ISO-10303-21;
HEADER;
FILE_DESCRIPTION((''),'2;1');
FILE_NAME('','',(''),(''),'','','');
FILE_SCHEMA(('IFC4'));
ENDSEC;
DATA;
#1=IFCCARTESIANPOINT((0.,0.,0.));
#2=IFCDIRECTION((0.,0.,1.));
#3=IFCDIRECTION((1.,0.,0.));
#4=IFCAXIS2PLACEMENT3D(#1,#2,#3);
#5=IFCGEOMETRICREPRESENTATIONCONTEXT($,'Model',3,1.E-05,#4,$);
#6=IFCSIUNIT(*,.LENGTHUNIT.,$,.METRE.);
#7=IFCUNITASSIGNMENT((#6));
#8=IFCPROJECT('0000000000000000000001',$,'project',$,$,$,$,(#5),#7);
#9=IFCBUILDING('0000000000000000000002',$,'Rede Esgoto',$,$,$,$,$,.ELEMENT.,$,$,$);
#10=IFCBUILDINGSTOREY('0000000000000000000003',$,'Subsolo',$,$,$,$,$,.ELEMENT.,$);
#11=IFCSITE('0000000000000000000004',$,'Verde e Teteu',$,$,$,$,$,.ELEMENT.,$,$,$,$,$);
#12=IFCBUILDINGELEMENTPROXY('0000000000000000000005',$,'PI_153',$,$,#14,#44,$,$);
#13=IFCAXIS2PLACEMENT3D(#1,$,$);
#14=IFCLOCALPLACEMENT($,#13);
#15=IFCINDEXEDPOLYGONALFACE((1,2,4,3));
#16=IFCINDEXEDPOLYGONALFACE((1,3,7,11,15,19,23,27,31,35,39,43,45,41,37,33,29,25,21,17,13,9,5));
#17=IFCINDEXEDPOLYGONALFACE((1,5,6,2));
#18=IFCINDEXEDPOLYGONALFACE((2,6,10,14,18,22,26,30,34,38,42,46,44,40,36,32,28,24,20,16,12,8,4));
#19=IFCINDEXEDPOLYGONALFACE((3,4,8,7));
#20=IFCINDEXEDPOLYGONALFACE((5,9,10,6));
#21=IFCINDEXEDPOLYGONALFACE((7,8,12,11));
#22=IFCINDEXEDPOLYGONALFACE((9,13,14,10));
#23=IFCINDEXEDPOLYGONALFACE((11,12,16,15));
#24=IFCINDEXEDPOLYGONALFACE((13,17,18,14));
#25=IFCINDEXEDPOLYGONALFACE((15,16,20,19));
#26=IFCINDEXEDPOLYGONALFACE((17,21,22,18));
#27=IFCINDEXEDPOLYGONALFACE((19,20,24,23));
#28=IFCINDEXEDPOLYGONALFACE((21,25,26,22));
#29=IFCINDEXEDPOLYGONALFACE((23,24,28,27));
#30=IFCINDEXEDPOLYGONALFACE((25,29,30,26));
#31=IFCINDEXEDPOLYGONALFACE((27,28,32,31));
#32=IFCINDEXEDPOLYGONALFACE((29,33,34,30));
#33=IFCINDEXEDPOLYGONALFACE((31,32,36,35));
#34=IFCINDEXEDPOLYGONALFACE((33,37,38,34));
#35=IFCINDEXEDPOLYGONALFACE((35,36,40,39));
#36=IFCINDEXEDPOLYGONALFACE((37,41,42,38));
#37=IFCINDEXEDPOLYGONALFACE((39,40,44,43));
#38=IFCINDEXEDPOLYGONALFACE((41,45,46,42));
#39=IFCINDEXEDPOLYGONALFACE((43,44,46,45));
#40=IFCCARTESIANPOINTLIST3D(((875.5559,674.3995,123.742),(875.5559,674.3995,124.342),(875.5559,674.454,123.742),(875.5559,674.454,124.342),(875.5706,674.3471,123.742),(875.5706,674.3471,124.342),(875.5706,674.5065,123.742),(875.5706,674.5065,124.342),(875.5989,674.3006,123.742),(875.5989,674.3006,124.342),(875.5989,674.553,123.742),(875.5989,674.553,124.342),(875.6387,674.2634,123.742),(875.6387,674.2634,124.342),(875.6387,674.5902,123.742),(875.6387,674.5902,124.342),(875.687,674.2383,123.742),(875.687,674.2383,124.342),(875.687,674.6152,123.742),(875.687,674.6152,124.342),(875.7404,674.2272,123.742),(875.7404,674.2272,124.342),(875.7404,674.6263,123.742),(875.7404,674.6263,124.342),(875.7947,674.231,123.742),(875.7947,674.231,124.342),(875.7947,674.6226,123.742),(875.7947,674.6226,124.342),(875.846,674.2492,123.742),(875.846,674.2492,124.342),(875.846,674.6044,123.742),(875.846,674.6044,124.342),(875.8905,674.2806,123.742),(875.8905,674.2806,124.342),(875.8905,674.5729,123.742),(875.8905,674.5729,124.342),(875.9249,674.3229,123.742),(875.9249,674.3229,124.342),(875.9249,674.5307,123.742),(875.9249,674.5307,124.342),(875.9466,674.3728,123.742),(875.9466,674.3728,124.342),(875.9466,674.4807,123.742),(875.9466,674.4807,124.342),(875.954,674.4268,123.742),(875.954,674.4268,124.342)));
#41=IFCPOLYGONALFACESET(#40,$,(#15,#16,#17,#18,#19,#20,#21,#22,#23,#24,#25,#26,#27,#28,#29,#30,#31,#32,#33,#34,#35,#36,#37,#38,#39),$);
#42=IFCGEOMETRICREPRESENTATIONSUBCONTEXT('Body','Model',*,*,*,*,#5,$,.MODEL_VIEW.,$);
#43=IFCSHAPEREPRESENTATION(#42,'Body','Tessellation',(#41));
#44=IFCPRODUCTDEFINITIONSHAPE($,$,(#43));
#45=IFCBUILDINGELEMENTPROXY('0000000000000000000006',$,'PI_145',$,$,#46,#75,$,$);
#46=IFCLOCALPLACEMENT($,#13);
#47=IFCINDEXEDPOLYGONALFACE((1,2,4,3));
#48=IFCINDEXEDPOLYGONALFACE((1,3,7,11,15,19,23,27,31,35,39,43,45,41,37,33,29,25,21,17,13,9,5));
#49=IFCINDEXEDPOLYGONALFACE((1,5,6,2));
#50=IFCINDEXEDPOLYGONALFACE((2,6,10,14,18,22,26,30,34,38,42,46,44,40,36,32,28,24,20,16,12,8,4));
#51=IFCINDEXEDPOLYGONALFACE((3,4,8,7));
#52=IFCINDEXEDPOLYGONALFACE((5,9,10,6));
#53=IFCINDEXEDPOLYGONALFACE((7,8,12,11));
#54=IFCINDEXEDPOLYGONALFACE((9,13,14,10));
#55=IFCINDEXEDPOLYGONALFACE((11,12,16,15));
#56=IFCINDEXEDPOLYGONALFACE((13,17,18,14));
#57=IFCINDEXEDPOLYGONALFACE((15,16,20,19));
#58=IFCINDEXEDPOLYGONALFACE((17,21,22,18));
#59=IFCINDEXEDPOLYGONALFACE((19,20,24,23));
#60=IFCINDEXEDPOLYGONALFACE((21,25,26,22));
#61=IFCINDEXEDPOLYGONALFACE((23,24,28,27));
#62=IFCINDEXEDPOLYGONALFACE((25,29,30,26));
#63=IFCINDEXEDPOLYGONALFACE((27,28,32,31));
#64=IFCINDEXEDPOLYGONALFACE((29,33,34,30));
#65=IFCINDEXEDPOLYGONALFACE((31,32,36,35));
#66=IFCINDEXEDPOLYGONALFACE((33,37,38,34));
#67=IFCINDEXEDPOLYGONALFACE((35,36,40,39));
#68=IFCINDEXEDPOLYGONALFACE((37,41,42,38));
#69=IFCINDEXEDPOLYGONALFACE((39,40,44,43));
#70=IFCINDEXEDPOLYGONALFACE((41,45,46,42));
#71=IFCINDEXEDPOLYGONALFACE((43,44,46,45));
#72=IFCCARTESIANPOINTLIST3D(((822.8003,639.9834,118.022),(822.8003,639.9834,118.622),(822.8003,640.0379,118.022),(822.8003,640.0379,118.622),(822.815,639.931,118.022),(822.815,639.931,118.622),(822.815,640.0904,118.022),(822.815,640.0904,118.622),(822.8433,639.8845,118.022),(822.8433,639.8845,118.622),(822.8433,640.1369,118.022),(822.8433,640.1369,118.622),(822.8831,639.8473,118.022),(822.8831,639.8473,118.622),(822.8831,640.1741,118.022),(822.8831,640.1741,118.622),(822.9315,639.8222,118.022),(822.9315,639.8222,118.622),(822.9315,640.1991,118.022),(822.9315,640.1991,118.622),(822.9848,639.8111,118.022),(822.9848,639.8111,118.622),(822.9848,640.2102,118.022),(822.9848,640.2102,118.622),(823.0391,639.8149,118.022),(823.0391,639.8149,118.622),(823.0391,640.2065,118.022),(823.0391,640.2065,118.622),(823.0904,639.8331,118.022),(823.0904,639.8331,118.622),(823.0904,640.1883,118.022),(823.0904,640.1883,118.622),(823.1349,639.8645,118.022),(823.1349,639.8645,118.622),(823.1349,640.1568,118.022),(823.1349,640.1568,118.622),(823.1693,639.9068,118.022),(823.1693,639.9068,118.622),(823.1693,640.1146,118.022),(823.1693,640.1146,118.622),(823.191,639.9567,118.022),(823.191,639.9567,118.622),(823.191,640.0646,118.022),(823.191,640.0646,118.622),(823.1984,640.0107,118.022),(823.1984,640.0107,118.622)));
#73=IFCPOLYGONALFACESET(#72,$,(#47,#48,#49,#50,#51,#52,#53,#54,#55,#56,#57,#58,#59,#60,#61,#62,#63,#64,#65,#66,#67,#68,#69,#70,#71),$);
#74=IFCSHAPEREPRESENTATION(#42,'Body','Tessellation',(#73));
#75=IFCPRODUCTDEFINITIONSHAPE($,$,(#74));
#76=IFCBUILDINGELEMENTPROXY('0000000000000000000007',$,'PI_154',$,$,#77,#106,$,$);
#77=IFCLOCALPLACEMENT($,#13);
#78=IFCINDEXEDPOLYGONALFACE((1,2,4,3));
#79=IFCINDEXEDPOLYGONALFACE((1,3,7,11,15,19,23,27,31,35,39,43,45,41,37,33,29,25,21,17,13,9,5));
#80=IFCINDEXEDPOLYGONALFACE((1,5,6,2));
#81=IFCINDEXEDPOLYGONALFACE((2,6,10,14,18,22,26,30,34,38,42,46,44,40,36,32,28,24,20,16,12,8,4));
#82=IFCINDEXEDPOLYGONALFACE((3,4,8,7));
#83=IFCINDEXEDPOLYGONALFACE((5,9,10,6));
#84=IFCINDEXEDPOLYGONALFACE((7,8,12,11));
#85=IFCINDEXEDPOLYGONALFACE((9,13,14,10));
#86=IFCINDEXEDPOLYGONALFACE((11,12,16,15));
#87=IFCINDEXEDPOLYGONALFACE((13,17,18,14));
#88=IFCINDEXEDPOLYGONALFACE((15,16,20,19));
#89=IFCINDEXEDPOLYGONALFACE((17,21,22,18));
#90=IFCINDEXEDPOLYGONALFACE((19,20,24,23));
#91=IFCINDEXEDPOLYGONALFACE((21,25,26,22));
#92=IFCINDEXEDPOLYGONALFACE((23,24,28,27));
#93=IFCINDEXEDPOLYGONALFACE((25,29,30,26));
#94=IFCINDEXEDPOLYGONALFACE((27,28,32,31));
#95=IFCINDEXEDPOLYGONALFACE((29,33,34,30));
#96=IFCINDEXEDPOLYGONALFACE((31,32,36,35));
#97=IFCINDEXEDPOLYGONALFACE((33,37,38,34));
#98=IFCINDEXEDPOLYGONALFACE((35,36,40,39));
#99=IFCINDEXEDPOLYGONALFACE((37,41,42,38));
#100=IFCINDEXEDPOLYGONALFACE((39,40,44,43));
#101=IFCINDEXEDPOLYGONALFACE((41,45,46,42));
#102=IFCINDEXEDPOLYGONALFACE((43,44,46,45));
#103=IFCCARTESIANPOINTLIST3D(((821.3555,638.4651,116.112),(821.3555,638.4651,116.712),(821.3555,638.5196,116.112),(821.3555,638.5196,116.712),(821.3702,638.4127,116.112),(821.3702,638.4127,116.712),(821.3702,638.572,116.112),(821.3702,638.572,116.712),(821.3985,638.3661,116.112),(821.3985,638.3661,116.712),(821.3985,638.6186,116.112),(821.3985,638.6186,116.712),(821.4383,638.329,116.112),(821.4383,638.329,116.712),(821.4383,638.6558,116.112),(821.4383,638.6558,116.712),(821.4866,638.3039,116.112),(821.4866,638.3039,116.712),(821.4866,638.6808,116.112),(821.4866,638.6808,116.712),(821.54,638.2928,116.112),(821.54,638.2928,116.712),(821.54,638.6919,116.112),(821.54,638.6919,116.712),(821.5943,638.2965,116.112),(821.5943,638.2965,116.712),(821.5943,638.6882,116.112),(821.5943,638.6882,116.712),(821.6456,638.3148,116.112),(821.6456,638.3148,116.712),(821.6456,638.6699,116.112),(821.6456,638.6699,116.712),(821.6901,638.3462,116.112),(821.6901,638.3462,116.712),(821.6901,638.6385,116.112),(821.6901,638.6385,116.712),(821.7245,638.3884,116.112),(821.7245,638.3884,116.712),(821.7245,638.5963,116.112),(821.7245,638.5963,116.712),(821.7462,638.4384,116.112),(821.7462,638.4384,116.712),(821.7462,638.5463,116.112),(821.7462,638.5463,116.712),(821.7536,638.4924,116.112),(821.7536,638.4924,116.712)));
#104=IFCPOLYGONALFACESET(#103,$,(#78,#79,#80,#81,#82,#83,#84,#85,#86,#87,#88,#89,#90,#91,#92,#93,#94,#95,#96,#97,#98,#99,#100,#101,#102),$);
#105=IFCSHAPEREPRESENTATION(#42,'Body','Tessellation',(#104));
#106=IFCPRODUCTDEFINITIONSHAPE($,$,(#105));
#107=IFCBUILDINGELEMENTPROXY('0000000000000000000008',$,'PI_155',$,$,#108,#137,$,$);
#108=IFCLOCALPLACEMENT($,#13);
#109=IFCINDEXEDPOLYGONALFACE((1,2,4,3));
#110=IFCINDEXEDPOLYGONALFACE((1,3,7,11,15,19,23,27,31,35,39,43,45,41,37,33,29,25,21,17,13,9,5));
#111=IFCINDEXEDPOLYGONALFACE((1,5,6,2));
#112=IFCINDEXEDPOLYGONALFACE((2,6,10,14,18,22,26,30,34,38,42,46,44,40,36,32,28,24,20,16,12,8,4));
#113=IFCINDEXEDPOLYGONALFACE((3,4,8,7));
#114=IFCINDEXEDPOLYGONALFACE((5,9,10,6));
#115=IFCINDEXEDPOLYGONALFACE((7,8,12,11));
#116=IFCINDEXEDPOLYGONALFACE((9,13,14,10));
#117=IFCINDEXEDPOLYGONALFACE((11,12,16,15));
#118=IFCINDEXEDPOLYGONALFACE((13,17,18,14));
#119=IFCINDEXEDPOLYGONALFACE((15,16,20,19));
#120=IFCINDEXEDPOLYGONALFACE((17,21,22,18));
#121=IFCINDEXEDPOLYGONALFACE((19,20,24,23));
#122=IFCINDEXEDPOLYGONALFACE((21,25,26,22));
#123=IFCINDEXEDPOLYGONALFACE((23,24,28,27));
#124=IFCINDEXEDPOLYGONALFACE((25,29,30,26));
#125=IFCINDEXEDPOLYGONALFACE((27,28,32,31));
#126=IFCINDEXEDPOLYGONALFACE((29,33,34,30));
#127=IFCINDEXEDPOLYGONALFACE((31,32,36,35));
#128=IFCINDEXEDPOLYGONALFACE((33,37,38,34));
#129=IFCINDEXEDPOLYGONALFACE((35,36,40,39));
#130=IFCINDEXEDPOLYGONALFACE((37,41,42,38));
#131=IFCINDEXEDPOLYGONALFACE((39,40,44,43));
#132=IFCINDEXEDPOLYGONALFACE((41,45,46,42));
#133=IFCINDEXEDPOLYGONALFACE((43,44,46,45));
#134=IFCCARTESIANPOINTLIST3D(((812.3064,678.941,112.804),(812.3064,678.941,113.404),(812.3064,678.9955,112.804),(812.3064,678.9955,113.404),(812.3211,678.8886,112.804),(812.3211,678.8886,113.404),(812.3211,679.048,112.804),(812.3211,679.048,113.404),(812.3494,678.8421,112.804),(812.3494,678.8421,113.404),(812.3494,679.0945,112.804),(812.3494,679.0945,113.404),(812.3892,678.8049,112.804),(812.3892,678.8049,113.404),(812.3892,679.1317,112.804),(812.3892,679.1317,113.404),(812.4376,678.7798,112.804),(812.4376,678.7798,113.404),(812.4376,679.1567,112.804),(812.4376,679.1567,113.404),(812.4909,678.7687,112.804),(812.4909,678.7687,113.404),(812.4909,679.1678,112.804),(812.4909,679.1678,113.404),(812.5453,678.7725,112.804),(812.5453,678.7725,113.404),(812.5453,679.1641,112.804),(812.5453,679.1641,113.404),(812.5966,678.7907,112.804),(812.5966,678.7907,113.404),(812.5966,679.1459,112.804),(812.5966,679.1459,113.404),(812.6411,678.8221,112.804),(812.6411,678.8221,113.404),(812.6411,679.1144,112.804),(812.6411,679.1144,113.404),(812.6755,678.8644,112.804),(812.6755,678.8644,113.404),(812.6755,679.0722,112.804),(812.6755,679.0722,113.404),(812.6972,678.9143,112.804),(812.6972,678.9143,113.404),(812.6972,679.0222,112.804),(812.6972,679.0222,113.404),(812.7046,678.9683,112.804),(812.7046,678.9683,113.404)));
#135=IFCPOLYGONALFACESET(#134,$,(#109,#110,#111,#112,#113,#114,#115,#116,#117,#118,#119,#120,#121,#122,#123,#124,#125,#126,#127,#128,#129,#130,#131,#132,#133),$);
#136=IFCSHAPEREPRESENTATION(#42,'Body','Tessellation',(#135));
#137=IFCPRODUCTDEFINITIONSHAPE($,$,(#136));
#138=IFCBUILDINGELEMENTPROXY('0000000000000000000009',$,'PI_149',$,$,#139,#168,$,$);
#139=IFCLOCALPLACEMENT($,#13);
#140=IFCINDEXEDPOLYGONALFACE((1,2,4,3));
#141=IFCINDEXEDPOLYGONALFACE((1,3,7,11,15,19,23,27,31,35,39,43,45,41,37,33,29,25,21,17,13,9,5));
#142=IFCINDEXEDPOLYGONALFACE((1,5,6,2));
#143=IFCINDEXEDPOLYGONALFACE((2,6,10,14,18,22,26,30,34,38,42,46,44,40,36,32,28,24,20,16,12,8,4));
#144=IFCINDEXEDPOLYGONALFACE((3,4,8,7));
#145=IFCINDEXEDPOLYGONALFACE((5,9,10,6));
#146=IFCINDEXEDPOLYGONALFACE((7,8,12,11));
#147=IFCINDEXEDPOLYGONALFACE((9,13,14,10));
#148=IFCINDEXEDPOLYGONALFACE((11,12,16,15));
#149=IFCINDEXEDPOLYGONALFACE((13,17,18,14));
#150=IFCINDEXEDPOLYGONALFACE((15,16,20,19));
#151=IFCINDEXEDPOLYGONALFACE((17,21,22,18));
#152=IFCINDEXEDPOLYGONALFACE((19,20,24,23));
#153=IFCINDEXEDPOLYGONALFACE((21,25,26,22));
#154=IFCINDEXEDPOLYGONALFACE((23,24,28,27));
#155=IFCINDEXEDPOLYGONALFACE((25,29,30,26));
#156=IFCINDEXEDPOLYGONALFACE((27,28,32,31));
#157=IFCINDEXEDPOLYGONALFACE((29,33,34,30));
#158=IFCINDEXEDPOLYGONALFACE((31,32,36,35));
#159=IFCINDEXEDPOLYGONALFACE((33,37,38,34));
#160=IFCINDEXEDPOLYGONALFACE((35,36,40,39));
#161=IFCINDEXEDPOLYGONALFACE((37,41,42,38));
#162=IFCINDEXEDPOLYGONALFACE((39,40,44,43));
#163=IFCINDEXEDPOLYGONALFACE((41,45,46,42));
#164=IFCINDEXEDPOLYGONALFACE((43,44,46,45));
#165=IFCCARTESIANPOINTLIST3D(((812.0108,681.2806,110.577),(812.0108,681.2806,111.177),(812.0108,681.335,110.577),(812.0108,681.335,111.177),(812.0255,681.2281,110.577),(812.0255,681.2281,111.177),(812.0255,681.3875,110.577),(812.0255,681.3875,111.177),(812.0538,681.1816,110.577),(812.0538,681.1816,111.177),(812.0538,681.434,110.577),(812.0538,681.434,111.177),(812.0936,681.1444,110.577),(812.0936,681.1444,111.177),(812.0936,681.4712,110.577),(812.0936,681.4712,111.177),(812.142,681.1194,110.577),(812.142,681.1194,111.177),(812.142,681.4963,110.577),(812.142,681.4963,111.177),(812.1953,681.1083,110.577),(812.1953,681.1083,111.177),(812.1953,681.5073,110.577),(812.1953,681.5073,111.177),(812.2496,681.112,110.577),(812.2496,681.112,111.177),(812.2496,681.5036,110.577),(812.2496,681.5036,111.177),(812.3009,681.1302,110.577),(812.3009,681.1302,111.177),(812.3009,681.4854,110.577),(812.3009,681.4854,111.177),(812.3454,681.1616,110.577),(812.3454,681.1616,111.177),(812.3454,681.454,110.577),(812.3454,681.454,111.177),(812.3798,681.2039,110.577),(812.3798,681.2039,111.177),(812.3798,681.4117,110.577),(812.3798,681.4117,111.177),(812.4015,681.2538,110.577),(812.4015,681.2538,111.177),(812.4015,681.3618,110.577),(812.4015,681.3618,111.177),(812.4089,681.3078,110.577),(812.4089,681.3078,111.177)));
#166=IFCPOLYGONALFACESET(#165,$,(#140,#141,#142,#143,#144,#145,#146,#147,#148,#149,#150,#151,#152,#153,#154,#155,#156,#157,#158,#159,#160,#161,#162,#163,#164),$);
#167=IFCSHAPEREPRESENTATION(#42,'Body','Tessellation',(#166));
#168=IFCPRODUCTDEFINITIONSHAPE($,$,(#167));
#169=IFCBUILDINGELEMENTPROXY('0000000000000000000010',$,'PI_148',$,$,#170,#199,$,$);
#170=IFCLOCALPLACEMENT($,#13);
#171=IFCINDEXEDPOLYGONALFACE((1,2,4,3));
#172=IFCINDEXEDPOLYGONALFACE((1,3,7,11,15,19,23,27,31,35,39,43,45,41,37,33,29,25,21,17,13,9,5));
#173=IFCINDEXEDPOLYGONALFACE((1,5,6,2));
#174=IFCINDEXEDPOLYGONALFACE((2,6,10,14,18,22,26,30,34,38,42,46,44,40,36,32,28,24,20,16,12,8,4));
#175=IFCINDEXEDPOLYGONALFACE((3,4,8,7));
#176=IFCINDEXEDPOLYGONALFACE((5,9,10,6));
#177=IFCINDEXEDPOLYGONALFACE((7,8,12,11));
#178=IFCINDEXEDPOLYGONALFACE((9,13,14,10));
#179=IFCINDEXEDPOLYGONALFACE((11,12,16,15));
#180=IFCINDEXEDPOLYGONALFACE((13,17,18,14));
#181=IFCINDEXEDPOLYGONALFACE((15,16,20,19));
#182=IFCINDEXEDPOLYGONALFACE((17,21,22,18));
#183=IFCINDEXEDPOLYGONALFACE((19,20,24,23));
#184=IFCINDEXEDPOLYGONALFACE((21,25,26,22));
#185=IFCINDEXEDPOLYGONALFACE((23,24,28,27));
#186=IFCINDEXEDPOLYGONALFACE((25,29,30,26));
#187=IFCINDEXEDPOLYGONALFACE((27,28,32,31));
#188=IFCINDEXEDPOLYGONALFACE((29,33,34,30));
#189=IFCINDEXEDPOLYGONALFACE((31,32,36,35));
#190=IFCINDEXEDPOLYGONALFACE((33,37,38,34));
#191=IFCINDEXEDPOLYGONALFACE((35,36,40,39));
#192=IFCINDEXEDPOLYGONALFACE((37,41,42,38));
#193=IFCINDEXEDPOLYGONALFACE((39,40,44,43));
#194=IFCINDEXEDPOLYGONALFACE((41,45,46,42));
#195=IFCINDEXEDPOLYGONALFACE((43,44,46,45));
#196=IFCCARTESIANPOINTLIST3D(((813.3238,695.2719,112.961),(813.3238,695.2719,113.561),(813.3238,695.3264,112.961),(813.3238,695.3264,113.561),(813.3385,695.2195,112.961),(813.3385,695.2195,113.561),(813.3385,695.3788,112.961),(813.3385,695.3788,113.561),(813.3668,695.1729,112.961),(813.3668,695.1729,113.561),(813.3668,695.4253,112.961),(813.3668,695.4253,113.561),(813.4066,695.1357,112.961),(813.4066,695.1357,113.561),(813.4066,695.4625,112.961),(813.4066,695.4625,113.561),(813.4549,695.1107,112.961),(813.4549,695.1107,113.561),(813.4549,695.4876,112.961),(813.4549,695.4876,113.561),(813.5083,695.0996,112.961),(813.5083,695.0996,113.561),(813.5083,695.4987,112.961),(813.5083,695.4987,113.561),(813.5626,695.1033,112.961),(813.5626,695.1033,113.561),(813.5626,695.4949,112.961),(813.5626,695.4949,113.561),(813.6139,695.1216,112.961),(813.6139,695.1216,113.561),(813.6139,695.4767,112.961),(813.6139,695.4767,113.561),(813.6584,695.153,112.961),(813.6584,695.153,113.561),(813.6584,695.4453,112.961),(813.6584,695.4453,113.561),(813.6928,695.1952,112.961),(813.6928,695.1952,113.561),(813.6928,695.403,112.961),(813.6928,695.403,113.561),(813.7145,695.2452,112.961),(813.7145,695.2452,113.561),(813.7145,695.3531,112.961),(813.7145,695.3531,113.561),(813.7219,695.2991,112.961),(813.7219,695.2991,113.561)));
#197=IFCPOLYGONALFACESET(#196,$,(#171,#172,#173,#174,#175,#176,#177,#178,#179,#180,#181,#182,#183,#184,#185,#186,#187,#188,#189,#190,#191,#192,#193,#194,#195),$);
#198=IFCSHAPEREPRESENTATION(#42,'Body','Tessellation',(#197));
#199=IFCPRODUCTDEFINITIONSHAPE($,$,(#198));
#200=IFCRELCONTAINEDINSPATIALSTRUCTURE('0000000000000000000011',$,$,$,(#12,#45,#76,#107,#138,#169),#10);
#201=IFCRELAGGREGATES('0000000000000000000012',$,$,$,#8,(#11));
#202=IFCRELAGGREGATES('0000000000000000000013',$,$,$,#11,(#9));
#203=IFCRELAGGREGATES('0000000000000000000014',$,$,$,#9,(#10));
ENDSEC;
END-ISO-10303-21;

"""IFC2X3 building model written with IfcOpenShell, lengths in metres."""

from ifc_helpers import new_model, si_unit, frame, origin_with_axes, origin_2d, place, context, subcontext, project, spatial, circle, extrude, element, save


model = new_model("IFC2X3")

# Units and contexts
model_context = context("Model", 3, precision=1e-05, world=origin_with_axes())
body_context = subcontext(model_context, "Body", "Model", "MODEL_VIEW")
ifc_project = project(units=[si_unit("LENGTHUNIT", "METRE")], contexts=[model_context])

# Site, building, storey
site = spatial("IfcSite", under=ifc_project, Name="Verde e Teteu", CompositionType="ELEMENT")
building = spatial("IfcBuilding", under=site, Name="Rede Esgoto", CompositionType="ELEMENT")
storey = spatial("IfcBuildingStorey", under=building, Name="Subsolo", CompositionType="ELEMENT")

# Building element proxies
for number, where, z_axis, x_axis, name in (
    (1, (875.754, 674.4268, 123.742), (0.0, 0.0, 1.0), (1.0, 0.0, 0.0), "PI_153"),
    (2, (822.9984, 640.0107, 118.022), (0.0, 0.0, 1.0), (1.0, 0.0, 0.0), "PI_145"),
):
    element("IfcBuildingElementProxy", number, at=place(None, frame(where, z_axis=z_axis, x_axis=x_axis)), inside=storey, Name=name, context=body_context, shape_type="SweptSolid", body=[
        extrude(circle(Radius=0.2, at=origin_2d()), origin_with_axes(), (0.0, 0.0, 1.0), 0.6),
    ])
proxy_1_placement = place(None, frame((821.5536, 638.4924, 116.112), z_axis=(0.0, 0.0, 1.0), x_axis=(1.0, 0.0, 0.0)))
element("IfcBuildingElementProxy", 3, at=proxy_1_placement, inside=storey, Name="PI_154", context=body_context, shape_type="SweptSolid", body=[
    extrude(circle(Radius=0.2, at=origin_2d()), origin_with_axes(), (0.0, 0.0, 1.0), 0.6),
])
proxy_2_placement = place(None, frame((812.5046, 678.9683, 112.804), z_axis=(0.0, 0.0, 1.0), x_axis=(1.0, 0.0, 0.0)))
element("IfcBuildingElementProxy", 4, at=proxy_2_placement, inside=storey, Name="PI_155", context=body_context, shape_type="SweptSolid", body=[
    extrude(circle(Radius=0.2, at=origin_2d()), origin_with_axes(), (0.0, 0.0, 1.0), 0.6),
])
for number, where, z_axis, x_axis, name in (
    (5, (812.2089, 681.3078, 110.577), (0.0, 0.0, 1.0), (1.0, 0.0, 0.0), "PI_149"),
    (6, (813.5219, 695.2991, 112.961), (0.0, 0.0, 1.0), (1.0, 0.0, 0.0), "PI_148"),
):
    element("IfcBuildingElementProxy", number, at=place(None, frame(where, z_axis=z_axis, x_axis=x_axis)), inside=storey, Name=name, context=body_context, shape_type="SweptSolid", body=[
        extrude(circle(Radius=0.2, at=origin_2d()), origin_with_axes(), (0.0, 0.0, 1.0), 0.6),
    ])

save(model, "model.ifc")
